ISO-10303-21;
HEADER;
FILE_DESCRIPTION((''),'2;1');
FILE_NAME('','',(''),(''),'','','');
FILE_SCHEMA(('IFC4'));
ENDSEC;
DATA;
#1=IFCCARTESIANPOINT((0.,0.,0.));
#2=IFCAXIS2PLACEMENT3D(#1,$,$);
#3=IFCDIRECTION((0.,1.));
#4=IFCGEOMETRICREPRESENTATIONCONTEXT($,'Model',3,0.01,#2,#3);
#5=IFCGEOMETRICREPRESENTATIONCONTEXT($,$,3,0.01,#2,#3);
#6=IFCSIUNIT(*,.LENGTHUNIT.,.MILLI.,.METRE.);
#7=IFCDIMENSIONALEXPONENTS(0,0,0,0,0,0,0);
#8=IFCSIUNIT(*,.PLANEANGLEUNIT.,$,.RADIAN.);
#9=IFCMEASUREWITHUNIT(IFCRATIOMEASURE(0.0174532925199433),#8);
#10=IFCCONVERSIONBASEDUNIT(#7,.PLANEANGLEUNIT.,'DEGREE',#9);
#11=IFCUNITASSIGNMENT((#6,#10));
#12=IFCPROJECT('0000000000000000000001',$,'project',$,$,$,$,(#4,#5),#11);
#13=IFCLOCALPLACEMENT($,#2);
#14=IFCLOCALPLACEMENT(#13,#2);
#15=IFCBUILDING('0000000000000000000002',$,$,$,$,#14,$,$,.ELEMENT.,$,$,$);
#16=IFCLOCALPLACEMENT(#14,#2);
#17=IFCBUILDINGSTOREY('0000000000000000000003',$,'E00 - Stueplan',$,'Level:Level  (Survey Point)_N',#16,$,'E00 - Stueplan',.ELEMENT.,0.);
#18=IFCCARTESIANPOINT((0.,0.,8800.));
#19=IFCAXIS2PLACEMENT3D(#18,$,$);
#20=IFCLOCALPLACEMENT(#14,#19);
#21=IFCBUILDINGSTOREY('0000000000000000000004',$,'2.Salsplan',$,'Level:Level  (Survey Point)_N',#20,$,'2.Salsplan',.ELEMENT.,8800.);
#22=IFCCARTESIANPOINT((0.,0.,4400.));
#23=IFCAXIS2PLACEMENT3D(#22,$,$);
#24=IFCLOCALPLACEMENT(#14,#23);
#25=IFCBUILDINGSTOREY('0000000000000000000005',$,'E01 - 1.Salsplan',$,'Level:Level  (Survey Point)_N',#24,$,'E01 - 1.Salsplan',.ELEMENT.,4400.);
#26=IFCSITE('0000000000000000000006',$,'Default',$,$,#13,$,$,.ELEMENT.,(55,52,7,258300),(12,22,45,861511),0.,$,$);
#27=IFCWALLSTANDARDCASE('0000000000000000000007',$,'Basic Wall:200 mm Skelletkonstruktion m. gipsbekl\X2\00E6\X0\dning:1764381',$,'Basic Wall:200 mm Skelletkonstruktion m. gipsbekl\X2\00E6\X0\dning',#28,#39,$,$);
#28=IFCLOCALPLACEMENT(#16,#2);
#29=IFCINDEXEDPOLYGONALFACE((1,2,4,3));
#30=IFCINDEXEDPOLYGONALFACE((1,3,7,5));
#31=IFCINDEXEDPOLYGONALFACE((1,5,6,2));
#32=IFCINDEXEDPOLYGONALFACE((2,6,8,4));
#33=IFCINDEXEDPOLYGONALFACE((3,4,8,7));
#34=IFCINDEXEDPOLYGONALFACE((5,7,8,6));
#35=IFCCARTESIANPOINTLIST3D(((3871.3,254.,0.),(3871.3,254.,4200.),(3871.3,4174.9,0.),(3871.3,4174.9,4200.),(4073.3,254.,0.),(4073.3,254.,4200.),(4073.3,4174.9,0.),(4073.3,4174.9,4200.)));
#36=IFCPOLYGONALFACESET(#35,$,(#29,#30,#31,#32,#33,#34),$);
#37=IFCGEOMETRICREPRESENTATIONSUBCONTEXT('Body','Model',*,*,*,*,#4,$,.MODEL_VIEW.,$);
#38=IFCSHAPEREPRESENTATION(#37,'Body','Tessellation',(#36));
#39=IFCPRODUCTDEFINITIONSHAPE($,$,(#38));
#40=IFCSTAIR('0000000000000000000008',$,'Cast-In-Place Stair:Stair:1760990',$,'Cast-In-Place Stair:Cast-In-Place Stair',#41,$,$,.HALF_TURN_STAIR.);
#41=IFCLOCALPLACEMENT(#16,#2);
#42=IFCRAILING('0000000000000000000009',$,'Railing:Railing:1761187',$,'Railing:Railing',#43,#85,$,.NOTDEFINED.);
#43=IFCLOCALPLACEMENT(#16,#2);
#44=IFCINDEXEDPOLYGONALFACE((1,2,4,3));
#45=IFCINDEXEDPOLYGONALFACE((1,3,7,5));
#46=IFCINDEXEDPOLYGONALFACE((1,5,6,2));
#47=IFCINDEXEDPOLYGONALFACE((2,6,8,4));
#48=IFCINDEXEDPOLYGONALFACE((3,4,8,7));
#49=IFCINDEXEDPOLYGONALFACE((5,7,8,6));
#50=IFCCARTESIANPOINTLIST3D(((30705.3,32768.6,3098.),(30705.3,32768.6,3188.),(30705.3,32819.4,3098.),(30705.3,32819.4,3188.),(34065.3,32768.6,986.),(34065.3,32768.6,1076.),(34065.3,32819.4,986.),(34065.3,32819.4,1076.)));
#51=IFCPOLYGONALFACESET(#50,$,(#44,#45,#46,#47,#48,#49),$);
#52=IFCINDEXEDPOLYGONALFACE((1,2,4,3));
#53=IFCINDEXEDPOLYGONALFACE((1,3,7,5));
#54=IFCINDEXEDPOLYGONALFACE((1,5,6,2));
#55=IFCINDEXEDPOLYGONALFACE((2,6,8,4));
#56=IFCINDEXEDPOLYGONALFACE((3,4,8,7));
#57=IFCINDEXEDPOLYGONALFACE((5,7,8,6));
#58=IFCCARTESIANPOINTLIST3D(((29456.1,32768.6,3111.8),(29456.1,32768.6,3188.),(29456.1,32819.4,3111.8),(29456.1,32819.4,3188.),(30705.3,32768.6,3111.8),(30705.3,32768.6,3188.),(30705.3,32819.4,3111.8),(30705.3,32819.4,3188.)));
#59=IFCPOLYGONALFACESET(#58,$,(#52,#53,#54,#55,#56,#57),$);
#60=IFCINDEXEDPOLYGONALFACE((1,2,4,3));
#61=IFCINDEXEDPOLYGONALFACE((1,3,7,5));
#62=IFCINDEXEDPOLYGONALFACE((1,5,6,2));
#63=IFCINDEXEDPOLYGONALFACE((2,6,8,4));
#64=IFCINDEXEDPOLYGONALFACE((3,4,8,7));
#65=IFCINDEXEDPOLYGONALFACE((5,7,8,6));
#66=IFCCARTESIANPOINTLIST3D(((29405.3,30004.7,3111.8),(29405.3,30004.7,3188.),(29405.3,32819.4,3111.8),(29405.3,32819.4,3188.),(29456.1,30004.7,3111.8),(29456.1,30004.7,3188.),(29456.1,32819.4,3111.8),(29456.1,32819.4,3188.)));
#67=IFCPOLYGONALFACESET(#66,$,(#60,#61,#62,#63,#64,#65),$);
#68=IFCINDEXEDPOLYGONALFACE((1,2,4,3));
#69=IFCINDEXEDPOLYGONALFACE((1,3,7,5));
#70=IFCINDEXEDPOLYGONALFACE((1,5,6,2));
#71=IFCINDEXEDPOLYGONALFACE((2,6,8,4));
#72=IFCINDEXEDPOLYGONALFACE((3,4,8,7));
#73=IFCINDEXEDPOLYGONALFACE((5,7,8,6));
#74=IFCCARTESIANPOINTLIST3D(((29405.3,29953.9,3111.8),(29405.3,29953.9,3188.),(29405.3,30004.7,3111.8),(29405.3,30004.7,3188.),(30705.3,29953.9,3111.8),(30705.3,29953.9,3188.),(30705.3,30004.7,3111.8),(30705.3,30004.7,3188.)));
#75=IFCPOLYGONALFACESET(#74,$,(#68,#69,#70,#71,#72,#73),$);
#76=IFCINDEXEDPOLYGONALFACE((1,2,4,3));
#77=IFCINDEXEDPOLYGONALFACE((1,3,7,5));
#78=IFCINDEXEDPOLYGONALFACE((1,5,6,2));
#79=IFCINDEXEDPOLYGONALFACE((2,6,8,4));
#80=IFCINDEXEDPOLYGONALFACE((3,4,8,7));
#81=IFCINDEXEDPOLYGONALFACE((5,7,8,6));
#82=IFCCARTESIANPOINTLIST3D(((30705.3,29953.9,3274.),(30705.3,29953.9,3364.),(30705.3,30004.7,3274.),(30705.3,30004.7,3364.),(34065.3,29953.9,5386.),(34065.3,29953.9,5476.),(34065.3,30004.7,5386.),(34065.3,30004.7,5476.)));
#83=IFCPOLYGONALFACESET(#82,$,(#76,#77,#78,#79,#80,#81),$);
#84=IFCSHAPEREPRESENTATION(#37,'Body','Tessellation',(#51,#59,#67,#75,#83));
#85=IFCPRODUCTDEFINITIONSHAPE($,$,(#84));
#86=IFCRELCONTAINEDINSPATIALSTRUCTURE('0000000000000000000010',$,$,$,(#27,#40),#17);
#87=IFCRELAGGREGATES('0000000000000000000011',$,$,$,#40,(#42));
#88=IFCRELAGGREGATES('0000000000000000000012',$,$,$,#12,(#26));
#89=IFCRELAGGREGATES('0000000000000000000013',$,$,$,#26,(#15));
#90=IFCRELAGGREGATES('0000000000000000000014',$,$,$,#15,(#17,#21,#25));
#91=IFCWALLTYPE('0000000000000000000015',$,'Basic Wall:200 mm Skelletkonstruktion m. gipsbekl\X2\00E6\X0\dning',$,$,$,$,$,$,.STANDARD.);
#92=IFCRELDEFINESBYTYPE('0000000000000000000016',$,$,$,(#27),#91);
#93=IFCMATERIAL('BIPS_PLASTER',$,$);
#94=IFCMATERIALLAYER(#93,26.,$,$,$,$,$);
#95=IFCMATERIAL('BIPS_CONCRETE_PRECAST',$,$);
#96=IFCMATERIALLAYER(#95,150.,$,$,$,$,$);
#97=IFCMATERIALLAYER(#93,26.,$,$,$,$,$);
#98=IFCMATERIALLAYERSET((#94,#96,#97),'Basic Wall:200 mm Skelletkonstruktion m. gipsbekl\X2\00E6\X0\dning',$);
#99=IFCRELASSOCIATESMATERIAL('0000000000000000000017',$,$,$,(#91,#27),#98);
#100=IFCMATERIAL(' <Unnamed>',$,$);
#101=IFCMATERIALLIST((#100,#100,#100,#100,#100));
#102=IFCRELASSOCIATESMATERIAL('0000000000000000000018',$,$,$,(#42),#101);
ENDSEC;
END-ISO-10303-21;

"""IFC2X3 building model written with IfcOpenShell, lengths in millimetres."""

from ifc_helpers import new_model, entity, si_unit, converted_unit, direction, frame, frame_2d, origin, place, context, subcontext, project, spatial, polyline, rectangle, outline, extrude, material, material_list, layer, layer_set, layer_usage, type_object, element, aggregate, save


model = new_model("IFC2X3")

# Units and contexts
model_context = context("Model", 3, precision=0.01, world=origin(), true_north=direction((0.0, 1.0)))
context_of_model = context(None, 3, precision=0.01, world=origin(), true_north=direction((0.0, 1.0)))
body_context = subcontext(model_context, "Body", "Model", "MODEL_VIEW")
ifc_project = project(units=[si_unit("LENGTHUNIT", "METRE", prefix="MILLI"), converted_unit("PLANEANGLEUNIT", "DEGREE", entity("IfcRatioMeasure", 0.0174532925199433), si_unit("PLANEANGLEUNIT", "RADIAN"), dimensions=[0, 0, 0, 0, 0, 0, 0])], contexts=[model_context, context_of_model])

# Site, building, storey
site_placement = place(None, origin())
site = spatial("IfcSite", under=ifc_project, at=site_placement, Name="Default", CompositionType="ELEMENT", RefLatitude=(55, 52, 7, 258300), RefLongitude=(12, 22, 45, 861511), RefElevation=0.0)
building_placement = place(site_placement, origin())
building = spatial("IfcBuilding", under=site, at=building_placement, CompositionType="ELEMENT")
storey_1_placement = place(building_placement, origin())
storey_1 = spatial("IfcBuildingStorey", under=building, at=storey_1_placement, Name="E00 - Stueplan", ObjectType="Level:Level  (Survey Point)_N", LongName="E00 - Stueplan", CompositionType="ELEMENT", Elevation=0.0)

# Shared definitions
ifc_material_1 = material(Name="BIPS_CONCRETE_PRECAST")

# Shared definitions
ifc_material_2 = material(Name=" <Unnamed>")

# Shared definitions
storey_2_placement = place(building_placement, frame((0.0, 0.0, 8800.0)))
storey_2 = spatial("IfcBuildingStorey", under=building, at=storey_2_placement, Name="2.Salsplan", ObjectType="Level:Level  (Survey Point)_N", LongName="2.Salsplan", CompositionType="ELEMENT", Elevation=8800.0)

# Shared definitions
storey_3_placement = place(building_placement, frame((0.0, 0.0, 4400.0)))
storey_3 = spatial("IfcBuildingStorey", under=building, at=storey_3_placement, Name="E01 - 1.Salsplan", ObjectType="Level:Level  (Survey Point)_N", LongName="E01 - 1.Salsplan", CompositionType="ELEMENT", Elevation=4400.0)

# Wall
ifc_material_3 = material(Name="BIPS_PLASTER")
ifc_layer_1 = layer(ifc_material_3, 26.0)
ifc_layer_2 = layer(ifc_material_1, 150.0)
ifc_layer_3 = layer(ifc_material_3, 26.0)
ifc_layer_set_1 = layer_set([ifc_layer_1, ifc_layer_2, ifc_layer_3], Name="Basic Wall:200 mm Skelletkonstruktion m. gipsbeklædning")
ifc_layer_usage_1 = layer_usage(ifc_layer_set_1, "AXIS2", "NEGATIVE", 101.0)
wall_type_1 = type_object("IfcWallType", Name="Basic Wall:200 mm Skelletkonstruktion m. gipsbeklædning", PredefinedType="STANDARD", material=ifc_layer_set_1)
wall_1_placement = place(storey_1_placement, frame((3972.3, 4174.9, 0.0), z_axis=(0.0, 0.0, 1.0), x_axis=(0.0, -1.0, 0.0)))
element("IfcWallStandardCase", 1, at=wall_1_placement, inside=storey_1, type_object=wall_type_1, material=ifc_layer_usage_1, Name="Basic Wall:200 mm Skelletkonstruktion m. gipsbeklædning:1764381", ObjectType="Basic Wall:200 mm Skelletkonstruktion m. gipsbeklædning", context=body_context, shape_type="SweptSolid", body=[
    extrude(rectangle(XDim=3920.9, YDim=202.0, at=frame_2d((1960.4, 0.0), x_axis=(-1.0, 0.0))), origin(), (0.0, 0.0, 1.0), 4200.0),
])

# Stair, railing
stair_placement = place(storey_1_placement, origin())
stair = element("IfcStair", 2, at=stair_placement, inside=storey_1, Name="Cast-In-Place Stair:Stair:1760990", ObjectType="Cast-In-Place Stair:Cast-In-Place Stair", ShapeType="HALF_TURN_STAIR")
ifc_material_list_1 = material_list([ifc_material_2, ifc_material_2, ifc_material_2, ifc_material_2, ifc_material_2])
railing_placement = place(stair_placement, origin())
railing = element("IfcRailing", 3, at=railing_placement, material=ifc_material_list_1, Name="Railing:Railing:1761187", ObjectType="Railing:Railing", PredefinedType="NOTDEFINED", context=body_context, shape_type="SweptSolid", body=[
    extrude(outline(polyline([(-2008.3, -38.1), (1960.4, -38.1), (2008.3, 38.1), (-1960.4, 38.1), (-2008.3, -38.1)])), frame((32385.3, 32768.6, 2087.0), z_axis=(0.0, 1.0, 0.0), x_axis=(-0.846637, 0.0, 0.532172)), (0.0, 0.0, 1.0), 50.8),
    extrude(rectangle(XDim=1249.2, YDim=50.8, at=frame_2d((0.0, 0.0), x_axis=(1.0, 0.0))), frame((30080.7, 32794.0, 3111.8), z_axis=(0.0, 0.0, 1.0), x_axis=(-1.0, 0.0, 0.0)), (0.0, 0.0, 1.0), 76.2),
    extrude(rectangle(XDim=2814.7, YDim=50.8, at=frame_2d((0.0, 0.0), x_axis=(1.0, 0.0))), frame((29430.7, 31412.0, 3111.8), z_axis=(0.0, 0.0, 1.0), x_axis=(0.0, -1.0, 0.0)), (0.0, 0.0, 1.0), 76.2),
    extrude(rectangle(XDim=1300.0, YDim=50.8, at=frame_2d((0.0, 0.0), x_axis=(1.0, 0.0))), frame((30055.3, 29979.3, 3111.8)), (0.0, 0.0, 1.0), 76.2),
    extrude(outline(polyline([(-1960.4, -38.1), (2008.3, -38.1), (1960.4, 38.1), (-2008.3, 38.1), (-1960.4, -38.1)])), frame((32385.3, 29953.9, 4375.0), z_axis=(0.0, 1.0, 0.0), x_axis=(0.846637, 0.0, 0.532172)), (0.0, 0.0, 1.0), 50.8),
])
aggregate(stair, [railing])

save(model, "model.ifc")
